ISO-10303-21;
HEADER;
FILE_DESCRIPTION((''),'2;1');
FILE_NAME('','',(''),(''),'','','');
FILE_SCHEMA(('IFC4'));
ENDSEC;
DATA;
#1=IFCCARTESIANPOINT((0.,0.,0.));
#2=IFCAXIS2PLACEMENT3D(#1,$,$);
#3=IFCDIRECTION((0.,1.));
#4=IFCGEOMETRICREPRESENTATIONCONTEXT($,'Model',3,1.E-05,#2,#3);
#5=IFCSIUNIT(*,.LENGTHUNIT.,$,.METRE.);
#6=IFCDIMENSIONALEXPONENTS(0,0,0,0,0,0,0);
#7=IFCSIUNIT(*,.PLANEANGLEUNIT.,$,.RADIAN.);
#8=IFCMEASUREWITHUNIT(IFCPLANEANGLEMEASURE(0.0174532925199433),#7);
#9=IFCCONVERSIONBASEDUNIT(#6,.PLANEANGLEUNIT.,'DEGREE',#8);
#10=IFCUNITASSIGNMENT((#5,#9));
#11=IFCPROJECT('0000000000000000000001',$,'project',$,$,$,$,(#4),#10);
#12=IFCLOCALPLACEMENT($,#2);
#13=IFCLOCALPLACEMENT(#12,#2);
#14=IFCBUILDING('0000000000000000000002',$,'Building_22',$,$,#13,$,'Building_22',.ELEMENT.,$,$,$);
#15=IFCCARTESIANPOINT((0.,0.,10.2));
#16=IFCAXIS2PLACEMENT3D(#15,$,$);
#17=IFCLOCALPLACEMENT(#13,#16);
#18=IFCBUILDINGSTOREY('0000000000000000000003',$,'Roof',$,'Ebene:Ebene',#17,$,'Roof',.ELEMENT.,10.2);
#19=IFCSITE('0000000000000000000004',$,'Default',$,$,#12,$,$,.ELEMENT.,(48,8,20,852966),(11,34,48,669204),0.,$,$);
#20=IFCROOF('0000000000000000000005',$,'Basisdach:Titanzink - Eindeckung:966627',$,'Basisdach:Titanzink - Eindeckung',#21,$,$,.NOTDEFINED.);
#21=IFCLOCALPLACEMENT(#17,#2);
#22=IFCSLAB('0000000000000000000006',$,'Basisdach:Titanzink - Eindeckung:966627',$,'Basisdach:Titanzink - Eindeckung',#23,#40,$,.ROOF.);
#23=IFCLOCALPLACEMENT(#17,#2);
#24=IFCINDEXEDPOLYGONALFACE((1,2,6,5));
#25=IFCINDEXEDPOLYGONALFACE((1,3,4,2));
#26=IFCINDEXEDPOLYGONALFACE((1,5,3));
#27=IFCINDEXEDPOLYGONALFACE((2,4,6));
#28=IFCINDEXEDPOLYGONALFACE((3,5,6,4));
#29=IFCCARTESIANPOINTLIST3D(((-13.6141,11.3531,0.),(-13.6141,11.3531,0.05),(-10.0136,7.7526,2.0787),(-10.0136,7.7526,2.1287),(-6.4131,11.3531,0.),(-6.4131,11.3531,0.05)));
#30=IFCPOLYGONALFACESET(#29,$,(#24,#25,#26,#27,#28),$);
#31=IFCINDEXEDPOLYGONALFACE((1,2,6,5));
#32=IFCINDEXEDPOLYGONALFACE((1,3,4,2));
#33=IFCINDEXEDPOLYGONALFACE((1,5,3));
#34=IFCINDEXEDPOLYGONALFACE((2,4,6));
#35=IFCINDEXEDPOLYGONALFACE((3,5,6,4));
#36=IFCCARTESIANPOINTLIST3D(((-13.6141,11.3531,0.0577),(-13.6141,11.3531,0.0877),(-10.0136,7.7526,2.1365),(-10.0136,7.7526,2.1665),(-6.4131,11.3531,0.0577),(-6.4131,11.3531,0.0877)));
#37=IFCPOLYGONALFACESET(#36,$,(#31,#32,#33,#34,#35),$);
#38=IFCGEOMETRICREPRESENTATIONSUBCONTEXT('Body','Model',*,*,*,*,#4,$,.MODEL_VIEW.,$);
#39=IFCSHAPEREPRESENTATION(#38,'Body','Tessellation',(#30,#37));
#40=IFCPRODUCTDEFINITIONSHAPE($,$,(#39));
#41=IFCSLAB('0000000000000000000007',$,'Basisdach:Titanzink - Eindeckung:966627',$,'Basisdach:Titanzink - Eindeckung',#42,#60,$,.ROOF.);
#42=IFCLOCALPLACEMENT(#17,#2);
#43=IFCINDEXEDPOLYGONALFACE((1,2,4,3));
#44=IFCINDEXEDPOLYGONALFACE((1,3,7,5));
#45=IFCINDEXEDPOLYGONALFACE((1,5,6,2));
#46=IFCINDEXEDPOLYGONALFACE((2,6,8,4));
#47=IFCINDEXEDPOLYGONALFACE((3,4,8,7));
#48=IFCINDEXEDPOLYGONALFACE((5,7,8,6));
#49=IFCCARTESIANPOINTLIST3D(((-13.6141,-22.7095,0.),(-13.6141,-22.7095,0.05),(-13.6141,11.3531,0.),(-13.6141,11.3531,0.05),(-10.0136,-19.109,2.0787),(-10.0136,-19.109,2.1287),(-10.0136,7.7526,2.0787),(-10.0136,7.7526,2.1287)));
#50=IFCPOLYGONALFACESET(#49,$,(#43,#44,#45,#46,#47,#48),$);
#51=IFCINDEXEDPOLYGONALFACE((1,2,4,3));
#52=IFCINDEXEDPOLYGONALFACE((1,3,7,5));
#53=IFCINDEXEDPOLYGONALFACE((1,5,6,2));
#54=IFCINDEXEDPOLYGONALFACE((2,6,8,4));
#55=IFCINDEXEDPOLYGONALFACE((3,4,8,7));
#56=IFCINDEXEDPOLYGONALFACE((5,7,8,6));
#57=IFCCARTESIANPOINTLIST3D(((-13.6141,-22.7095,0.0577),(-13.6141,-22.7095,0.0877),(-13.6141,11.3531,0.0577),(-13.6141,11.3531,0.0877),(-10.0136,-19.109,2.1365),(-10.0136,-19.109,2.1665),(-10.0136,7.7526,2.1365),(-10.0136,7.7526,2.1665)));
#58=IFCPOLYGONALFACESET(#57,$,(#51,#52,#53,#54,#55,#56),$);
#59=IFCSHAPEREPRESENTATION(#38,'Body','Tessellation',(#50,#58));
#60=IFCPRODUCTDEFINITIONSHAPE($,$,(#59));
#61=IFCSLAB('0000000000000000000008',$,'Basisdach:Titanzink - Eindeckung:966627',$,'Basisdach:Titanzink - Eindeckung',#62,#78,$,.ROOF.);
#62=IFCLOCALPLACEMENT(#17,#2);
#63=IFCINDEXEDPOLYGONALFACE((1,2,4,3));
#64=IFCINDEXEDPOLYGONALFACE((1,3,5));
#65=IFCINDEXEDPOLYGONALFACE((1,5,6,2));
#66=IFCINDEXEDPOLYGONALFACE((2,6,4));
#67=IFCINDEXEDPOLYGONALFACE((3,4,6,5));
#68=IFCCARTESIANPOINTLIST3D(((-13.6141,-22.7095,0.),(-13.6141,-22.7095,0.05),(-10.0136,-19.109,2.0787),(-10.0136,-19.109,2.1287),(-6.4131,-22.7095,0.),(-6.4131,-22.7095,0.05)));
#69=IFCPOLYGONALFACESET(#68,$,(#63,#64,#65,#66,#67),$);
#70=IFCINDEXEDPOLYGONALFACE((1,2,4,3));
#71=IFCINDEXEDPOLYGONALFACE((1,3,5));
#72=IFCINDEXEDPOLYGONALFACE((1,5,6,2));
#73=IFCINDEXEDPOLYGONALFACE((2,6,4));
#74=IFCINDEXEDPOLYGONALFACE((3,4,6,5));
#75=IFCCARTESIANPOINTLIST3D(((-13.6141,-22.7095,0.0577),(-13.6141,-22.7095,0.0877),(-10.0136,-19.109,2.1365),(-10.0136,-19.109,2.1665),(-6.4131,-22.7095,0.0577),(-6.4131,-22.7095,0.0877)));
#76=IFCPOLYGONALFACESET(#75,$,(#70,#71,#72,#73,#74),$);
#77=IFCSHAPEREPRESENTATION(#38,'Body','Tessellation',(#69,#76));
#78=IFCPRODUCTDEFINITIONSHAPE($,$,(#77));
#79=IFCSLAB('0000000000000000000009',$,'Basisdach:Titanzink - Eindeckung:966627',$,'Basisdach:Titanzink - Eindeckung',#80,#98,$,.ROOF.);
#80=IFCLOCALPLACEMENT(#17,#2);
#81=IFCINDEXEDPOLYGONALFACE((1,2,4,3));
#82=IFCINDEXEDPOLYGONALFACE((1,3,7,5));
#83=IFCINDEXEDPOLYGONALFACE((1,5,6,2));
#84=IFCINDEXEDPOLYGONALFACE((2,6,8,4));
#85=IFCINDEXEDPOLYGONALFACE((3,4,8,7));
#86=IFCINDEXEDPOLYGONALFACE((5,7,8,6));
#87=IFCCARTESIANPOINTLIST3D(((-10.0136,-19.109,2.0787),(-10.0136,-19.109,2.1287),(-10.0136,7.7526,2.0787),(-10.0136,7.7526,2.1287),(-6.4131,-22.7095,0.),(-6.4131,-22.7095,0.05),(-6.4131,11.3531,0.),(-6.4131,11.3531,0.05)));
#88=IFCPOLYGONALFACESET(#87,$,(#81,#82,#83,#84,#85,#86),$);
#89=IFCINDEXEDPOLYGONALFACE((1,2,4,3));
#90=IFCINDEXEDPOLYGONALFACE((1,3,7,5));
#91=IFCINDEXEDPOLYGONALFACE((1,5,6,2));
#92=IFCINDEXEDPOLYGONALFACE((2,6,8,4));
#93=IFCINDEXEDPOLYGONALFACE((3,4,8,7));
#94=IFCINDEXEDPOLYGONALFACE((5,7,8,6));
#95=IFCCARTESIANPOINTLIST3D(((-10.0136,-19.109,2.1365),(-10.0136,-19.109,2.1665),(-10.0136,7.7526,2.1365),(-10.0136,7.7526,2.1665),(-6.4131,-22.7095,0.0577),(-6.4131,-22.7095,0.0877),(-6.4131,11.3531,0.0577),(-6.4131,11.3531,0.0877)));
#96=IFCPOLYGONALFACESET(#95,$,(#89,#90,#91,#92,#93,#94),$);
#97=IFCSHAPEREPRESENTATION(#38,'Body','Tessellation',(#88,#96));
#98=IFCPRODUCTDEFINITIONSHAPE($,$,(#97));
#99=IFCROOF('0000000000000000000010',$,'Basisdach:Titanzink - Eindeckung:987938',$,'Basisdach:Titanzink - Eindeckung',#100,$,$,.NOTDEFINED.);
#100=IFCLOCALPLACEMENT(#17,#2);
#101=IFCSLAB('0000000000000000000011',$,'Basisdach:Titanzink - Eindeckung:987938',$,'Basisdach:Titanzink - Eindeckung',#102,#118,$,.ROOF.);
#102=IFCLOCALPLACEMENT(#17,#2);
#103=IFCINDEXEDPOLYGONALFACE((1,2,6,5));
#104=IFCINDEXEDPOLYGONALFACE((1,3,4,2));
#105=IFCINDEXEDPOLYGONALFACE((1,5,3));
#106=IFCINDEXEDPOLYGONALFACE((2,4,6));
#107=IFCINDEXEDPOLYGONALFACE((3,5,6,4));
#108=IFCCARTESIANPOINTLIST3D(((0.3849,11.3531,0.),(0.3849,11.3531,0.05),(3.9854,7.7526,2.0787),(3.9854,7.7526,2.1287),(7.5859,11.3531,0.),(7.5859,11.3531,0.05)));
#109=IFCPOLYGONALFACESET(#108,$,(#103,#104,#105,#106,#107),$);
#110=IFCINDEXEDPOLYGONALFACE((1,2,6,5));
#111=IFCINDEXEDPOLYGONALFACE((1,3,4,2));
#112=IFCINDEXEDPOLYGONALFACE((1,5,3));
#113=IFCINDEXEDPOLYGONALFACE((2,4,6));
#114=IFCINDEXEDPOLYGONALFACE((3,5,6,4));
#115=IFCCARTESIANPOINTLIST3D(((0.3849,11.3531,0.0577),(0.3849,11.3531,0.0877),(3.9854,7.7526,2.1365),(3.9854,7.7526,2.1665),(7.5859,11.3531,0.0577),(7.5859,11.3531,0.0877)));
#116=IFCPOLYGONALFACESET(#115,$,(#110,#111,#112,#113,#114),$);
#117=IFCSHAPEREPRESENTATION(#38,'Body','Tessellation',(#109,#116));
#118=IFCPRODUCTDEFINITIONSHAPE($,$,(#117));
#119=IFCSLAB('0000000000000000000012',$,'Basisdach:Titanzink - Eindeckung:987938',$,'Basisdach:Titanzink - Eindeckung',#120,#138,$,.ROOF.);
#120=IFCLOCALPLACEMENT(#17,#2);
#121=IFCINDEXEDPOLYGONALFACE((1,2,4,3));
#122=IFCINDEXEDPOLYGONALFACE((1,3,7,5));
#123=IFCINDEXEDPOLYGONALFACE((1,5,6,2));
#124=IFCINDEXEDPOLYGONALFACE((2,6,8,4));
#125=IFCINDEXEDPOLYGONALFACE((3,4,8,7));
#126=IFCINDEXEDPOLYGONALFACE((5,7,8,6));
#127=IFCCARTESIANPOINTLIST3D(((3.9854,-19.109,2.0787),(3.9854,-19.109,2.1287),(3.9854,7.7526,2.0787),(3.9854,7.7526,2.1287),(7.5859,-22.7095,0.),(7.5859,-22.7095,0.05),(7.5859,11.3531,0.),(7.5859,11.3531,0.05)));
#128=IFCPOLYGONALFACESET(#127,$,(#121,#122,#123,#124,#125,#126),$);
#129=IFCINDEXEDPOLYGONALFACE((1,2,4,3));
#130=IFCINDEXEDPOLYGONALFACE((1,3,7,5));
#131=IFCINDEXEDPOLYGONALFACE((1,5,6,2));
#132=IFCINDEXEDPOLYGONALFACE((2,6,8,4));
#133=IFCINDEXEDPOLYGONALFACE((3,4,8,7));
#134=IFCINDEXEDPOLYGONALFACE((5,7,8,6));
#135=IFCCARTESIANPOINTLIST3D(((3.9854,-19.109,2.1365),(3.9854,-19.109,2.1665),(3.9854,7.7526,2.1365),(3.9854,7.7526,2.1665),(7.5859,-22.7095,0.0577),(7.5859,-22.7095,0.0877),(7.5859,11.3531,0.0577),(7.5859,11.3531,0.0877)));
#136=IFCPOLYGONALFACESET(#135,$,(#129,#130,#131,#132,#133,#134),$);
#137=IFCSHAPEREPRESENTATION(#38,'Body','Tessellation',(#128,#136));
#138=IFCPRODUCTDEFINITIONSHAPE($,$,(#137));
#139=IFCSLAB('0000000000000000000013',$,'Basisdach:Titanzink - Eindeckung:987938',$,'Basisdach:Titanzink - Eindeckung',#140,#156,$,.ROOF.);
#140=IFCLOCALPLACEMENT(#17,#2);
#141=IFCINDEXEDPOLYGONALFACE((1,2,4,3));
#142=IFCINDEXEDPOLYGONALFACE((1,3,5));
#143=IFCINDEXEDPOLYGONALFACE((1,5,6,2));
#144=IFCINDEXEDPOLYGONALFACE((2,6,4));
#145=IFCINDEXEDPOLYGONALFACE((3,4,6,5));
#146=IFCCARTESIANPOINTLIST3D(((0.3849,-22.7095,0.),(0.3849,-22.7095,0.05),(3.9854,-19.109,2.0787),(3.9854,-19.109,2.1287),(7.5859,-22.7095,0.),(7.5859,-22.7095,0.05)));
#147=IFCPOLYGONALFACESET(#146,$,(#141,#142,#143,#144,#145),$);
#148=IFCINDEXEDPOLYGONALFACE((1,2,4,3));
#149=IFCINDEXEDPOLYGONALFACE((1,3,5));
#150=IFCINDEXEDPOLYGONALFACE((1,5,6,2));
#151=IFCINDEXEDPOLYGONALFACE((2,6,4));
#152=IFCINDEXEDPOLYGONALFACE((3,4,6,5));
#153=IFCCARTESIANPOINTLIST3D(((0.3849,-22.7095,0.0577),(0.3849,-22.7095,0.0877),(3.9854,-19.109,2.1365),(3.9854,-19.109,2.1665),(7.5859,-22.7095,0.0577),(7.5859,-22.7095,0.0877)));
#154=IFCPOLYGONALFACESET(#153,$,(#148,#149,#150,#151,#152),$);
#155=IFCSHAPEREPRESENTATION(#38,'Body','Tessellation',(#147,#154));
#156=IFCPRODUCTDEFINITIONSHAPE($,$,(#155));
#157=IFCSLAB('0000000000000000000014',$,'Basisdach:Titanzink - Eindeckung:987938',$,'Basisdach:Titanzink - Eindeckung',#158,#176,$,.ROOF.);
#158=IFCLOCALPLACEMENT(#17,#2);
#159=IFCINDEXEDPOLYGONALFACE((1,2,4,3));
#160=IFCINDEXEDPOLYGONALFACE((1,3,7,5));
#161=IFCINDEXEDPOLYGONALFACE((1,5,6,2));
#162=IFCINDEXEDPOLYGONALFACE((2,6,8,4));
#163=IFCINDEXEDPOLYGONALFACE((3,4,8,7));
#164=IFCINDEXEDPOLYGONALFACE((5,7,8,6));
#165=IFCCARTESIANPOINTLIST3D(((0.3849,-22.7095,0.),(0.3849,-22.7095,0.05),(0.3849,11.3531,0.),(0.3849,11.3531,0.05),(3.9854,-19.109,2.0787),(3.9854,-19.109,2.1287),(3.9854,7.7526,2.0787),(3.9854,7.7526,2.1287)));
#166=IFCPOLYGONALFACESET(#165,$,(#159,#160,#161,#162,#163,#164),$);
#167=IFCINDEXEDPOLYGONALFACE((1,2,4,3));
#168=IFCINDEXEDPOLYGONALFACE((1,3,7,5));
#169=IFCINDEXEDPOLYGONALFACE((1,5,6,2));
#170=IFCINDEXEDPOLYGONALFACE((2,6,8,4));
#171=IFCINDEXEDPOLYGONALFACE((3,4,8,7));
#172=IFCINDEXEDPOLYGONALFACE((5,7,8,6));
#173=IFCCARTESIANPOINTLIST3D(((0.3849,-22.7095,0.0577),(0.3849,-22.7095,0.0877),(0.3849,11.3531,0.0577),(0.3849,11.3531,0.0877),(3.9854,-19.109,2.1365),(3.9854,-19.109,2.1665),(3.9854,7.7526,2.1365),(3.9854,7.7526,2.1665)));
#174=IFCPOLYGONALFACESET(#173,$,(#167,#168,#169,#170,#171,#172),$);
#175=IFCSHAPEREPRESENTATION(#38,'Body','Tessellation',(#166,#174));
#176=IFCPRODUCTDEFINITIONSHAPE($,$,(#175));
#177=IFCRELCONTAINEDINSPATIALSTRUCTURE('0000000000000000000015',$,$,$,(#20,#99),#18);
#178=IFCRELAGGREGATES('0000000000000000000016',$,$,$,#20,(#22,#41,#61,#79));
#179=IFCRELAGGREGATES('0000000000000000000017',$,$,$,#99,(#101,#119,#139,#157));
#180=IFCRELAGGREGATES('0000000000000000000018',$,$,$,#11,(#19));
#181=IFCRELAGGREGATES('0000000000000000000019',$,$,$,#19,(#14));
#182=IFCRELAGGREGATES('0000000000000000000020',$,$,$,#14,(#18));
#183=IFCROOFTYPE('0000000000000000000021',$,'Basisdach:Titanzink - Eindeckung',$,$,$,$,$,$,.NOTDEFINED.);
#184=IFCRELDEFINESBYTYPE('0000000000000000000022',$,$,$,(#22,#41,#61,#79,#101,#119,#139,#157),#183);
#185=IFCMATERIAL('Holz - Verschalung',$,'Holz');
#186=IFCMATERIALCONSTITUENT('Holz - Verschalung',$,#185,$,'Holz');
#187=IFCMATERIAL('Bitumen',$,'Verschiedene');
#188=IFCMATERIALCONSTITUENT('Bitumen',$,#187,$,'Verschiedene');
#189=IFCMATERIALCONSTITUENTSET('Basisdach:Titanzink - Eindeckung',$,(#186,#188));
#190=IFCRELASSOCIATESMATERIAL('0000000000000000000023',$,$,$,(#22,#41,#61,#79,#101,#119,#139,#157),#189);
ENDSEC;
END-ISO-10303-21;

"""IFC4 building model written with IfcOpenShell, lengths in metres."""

from ifc_helpers import new_model, entity, si_unit, converted_unit, direction, frame, origin, place, context, subcontext, project, spatial, indexed_curve, outline, extrude, material, constituent, constituent_set, type_object, element, aggregate, save


model = new_model("IFC4")

# Units and contexts
model_context = context("Model", 3, precision=1e-05, world=origin(), true_north=direction((0.0, 1.0)))
body_context = subcontext(model_context, "Body", "Model", "MODEL_VIEW")
ifc_project = project(units=[si_unit("LENGTHUNIT", "METRE"), converted_unit("PLANEANGLEUNIT", "DEGREE", entity("IfcPlaneAngleMeasure", 0.0174532925199433), si_unit("PLANEANGLEUNIT", "RADIAN"), dimensions=[0, 0, 0, 0, 0, 0, 0])], contexts=[model_context])

# Site, building, storey
site_placement = place(None, origin())
site = spatial("IfcSite", under=ifc_project, at=site_placement, Name="Default", CompositionType="ELEMENT", RefLatitude=(48, 8, 20, 852966), RefLongitude=(11, 34, 48, 669204), RefElevation=0.0)
building_placement = place(site_placement, origin())
building = spatial("IfcBuilding", under=site, at=building_placement, Name="Building_22", LongName="Building_22", CompositionType="ELEMENT")
storey_placement = place(building_placement, frame((0.0, 0.0, 10.2)))
storey = spatial("IfcBuildingStorey", under=building, at=storey_placement, Name="Roof", ObjectType="Ebene:Ebene", LongName="Roof", CompositionType="ELEMENT", Elevation=10.2)

# Roofs, slabs
roof_1_placement = place(storey_placement, frame((-13.6141, -22.7095, 0.0)))
roof_1 = element("IfcRoof", 1, at=roof_1_placement, inside=storey, Name="Basisdach:Titanzink - Eindeckung:966627", ObjectType="Basisdach:Titanzink - Eindeckung", PredefinedType="NOTDEFINED")
ifc_material_1 = material(Name="Holz - Verschalung", Category="Holz")
ifc_constituent_1 = constituent(ifc_material_1, Name="Holz - Verschalung", Category="Holz")
ifc_material_2 = material(Name="Bitumen", Category="Verschiedene")
ifc_constituent_2 = constituent(ifc_material_2, Name="Bitumen", Category="Verschiedene")
ifc_constituent_set = constituent_set(constituents=[ifc_constituent_1, ifc_constituent_2], Name="Basisdach:Titanzink - Eindeckung")
roof_type = type_object("IfcRoofType", Name="Basisdach:Titanzink - Eindeckung", PredefinedType="NOTDEFINED")
slab_1_placement = place(roof_1_placement, origin())
slab_1 = element("IfcSlab", 2, at=slab_1_placement, type_object=roof_type, material=ifc_constituent_set, Name="Basisdach:Titanzink - Eindeckung:966627", ObjectType="Basisdach:Titanzink - Eindeckung", PredefinedType="ROOF", context=body_context, shape_type="SweptSolid", body=[
    extrude(outline(indexed_curve([(3.6005, 2.0787), (-3.6005, 2.0787), (0.0, -2.0787), (3.6005, 2.0787)], self_intersect=False)), frame((3.6005, 32.2624, 1.0394), z_axis=(0.0, 0.5, 0.866025), x_axis=(1.0, 0.0, 0.0)), (0.0, -0.5, 0.866025), 0.05),
    extrude(outline(indexed_curve([(3.6005, 2.0787), (-3.6005, 2.0787), (0.0, -2.0787), (3.6005, 2.0787)], self_intersect=False)), frame((3.6005, 32.2624, 1.0971), z_axis=(0.0, 0.5, 0.866025), x_axis=(1.0, 0.0, 0.0)), (0.0, -0.5, 0.866025), 0.03),
])
slab_2_placement = place(roof_1_placement, origin())
slab_2 = element("IfcSlab", 3, at=slab_2_placement, type_object=roof_type, material=ifc_constituent_set, Name="Basisdach:Titanzink - Eindeckung:966627", ObjectType="Basisdach:Titanzink - Eindeckung", PredefinedType="ROOF", context=body_context, shape_type="SweptSolid", body=[
    extrude(outline(indexed_curve([(-2.0787, 17.0313), (-2.0787, -17.0313), (2.0787, -13.4308), (2.0787, 13.4308), (-2.0787, 17.0313)], self_intersect=False)), frame((1.8002, 17.0313, 1.0394), z_axis=(-0.5, 0.0, 0.866025), x_axis=(0.866025, 0.0, 0.5)), (0.5, 0.0, 0.866025), 0.05),
    extrude(outline(indexed_curve([(-2.0787, 17.0313), (-2.0787, -17.0313), (2.0787, -13.4308), (2.0787, 13.4308), (-2.0787, 17.0313)], self_intersect=False)), frame((1.8002, 17.0313, 1.0971), z_axis=(-0.5, 0.0, 0.866025), x_axis=(0.866025, 0.0, 0.5)), (0.5, 0.0, 0.866025), 0.03),
])
slab_3_placement = place(roof_1_placement, origin())
slab_3 = element("IfcSlab", 4, at=slab_3_placement, type_object=roof_type, material=ifc_constituent_set, Name="Basisdach:Titanzink - Eindeckung:966627", ObjectType="Basisdach:Titanzink - Eindeckung", PredefinedType="ROOF", context=body_context, shape_type="SweptSolid", body=[
    extrude(outline(indexed_curve([(-3.6005, -2.0787), (3.6005, -2.0787), (0.0, 2.0787), (-3.6005, -2.0787)], self_intersect=False)), frame((3.6005, 1.8002, 1.0394), z_axis=(0.0, -0.5, 0.866025), x_axis=(1.0, 0.0, 0.0)), (0.0, 0.5, 0.866025), 0.05),
    extrude(outline(indexed_curve([(-3.6005, -2.0787), (3.6005, -2.0787), (0.0, 2.0787), (-3.6005, -2.0787)], self_intersect=False)), frame((3.6005, 1.8002, 1.0971), z_axis=(0.0, -0.5, 0.866025), x_axis=(1.0, 0.0, 0.0)), (0.0, 0.5, 0.866025), 0.03),
])
slab_4_placement = place(roof_1_placement, origin())
slab_4 = element("IfcSlab", 5, at=slab_4_placement, type_object=roof_type, material=ifc_constituent_set, Name="Basisdach:Titanzink - Eindeckung:966627", ObjectType="Basisdach:Titanzink - Eindeckung", PredefinedType="ROOF", context=body_context, shape_type="SweptSolid", body=[
    extrude(outline(indexed_curve([(-2.0787, 13.4308), (-2.0787, -13.4308), (2.0787, -17.0313), (2.0787, 17.0313), (-2.0787, 13.4308)], self_intersect=False)), frame((5.4008, 17.0313, 1.0394), z_axis=(0.5, 0.0, 0.866025), x_axis=(0.866025, 0.0, -0.5)), (-0.5, 0.0, 0.866025), 0.05),
    extrude(outline(indexed_curve([(-2.0787, 13.4308), (-2.0787, -13.4308), (2.0787, -17.0313), (2.0787, 17.0313), (-2.0787, 13.4308)], self_intersect=False)), frame((5.4008, 17.0313, 1.0971), z_axis=(0.5, 0.0, 0.866025), x_axis=(0.866025, 0.0, -0.5)), (-0.5, 0.0, 0.866025), 0.03),
])
aggregate(roof_1, [slab_1, slab_2, slab_3, slab_4])
roof_2_placement = place(storey_placement, frame((0.3849, -22.7095, 0.0)))
roof_2 = element("IfcRoof", 6, at=roof_2_placement, inside=storey, Name="Basisdach:Titanzink - Eindeckung:987938", ObjectType="Basisdach:Titanzink - Eindeckung", PredefinedType="NOTDEFINED")
slab_5_placement = place(roof_2_placement, origin())
slab_5 = element("IfcSlab", 7, at=slab_5_placement, type_object=roof_type, material=ifc_constituent_set, Name="Basisdach:Titanzink - Eindeckung:987938", ObjectType="Basisdach:Titanzink - Eindeckung", PredefinedType="ROOF", context=body_context, shape_type="SweptSolid", body=[
    extrude(outline(indexed_curve([(0.0, -2.0787), (3.6005, 2.0787), (-3.6005, 2.0787), (0.0, -2.0787)], self_intersect=False)), frame((3.6005, 32.2624, 1.0394), z_axis=(0.0, 0.5, 0.866025), x_axis=(1.0, 0.0, 0.0)), (0.0, -0.5, 0.866025), 0.05),
    extrude(outline(indexed_curve([(0.0, -2.0787), (3.6005, 2.0787), (-3.6005, 2.0787), (0.0, -2.0787)], self_intersect=False)), frame((3.6005, 32.2624, 1.0971), z_axis=(0.0, 0.5, 0.866025), x_axis=(1.0, 0.0, 0.0)), (0.0, -0.5, 0.866025), 0.03),
])
slab_6_placement = place(roof_2_placement, origin())
slab_6 = element("IfcSlab", 8, at=slab_6_placement, type_object=roof_type, material=ifc_constituent_set, Name="Basisdach:Titanzink - Eindeckung:987938", ObjectType="Basisdach:Titanzink - Eindeckung", PredefinedType="ROOF", context=body_context, shape_type="SweptSolid", body=[
    extrude(outline(indexed_curve([(2.0787, -17.0313), (2.0787, 17.0313), (-2.0787, 13.4308), (-2.0787, -13.4308), (2.0787, -17.0313)], self_intersect=False)), frame((5.4008, 17.0313, 1.0394), z_axis=(0.5, 0.0, 0.866025), x_axis=(0.866025, 0.0, -0.5)), (-0.5, 0.0, 0.866025), 0.05),
    extrude(outline(indexed_curve([(2.0787, -17.0313), (2.0787, 17.0313), (-2.0787, 13.4308), (-2.0787, -13.4308), (2.0787, -17.0313)], self_intersect=False)), frame((5.4008, 17.0313, 1.0971), z_axis=(0.5, 0.0, 0.866025), x_axis=(0.866025, 0.0, -0.5)), (-0.5, 0.0, 0.866025), 0.03),
])
slab_7_placement = place(roof_2_placement, origin())
slab_7 = element("IfcSlab", 9, at=slab_7_placement, type_object=roof_type, material=ifc_constituent_set, Name="Basisdach:Titanzink - Eindeckung:987938", ObjectType="Basisdach:Titanzink - Eindeckung", PredefinedType="ROOF", context=body_context, shape_type="SweptSolid", body=[
    extrude(outline(indexed_curve([(-3.6005, -2.0787), (3.6005, -2.0787), (0.0, 2.0787), (-3.6005, -2.0787)], self_intersect=False)), frame((3.6005, 1.8002, 1.0394), z_axis=(0.0, -0.5, 0.866025), x_axis=(1.0, 0.0, 0.0)), (0.0, 0.5, 0.866025), 0.05),
    extrude(outline(indexed_curve([(-3.6005, -2.0787), (3.6005, -2.0787), (0.0, 2.0787), (-3.6005, -2.0787)], self_intersect=False)), frame((3.6005, 1.8002, 1.0971), z_axis=(0.0, -0.5, 0.866025), x_axis=(1.0, 0.0, 0.0)), (0.0, 0.5, 0.866025), 0.03),
])
slab_8_placement = place(roof_2_placement, origin())
slab_8 = element("IfcSlab", 10, at=slab_8_placement, type_object=roof_type, material=ifc_constituent_set, Name="Basisdach:Titanzink - Eindeckung:987938", ObjectType="Basisdach:Titanzink - Eindeckung", PredefinedType="ROOF", context=body_context, shape_type="SweptSolid", body=[
    extrude(outline(indexed_curve([(-2.0787, 17.0313), (-2.0787, -17.0313), (2.0787, -13.4308), (2.0787, 13.4308), (-2.0787, 17.0313)], self_intersect=False)), frame((1.8003, 17.0313, 1.0394), z_axis=(-0.5, 0.0, 0.866025), x_axis=(0.866025, 0.0, 0.5)), (0.5, 0.0, 0.866025), 0.05),
    extrude(outline(indexed_curve([(-2.0787, 17.0313), (-2.0787, -17.0313), (2.0787, -13.4308), (2.0787, 13.4308), (-2.0787, 17.0313)], self_intersect=False)), frame((1.8003, 17.0313, 1.0971), z_axis=(-0.5, 0.0, 0.866025), x_axis=(0.866025, 0.0, 0.5)), (0.5, 0.0, 0.866025), 0.03),
])
aggregate(roof_2, [slab_5, slab_6, slab_7, slab_8])

save(model, "model.ifc")
